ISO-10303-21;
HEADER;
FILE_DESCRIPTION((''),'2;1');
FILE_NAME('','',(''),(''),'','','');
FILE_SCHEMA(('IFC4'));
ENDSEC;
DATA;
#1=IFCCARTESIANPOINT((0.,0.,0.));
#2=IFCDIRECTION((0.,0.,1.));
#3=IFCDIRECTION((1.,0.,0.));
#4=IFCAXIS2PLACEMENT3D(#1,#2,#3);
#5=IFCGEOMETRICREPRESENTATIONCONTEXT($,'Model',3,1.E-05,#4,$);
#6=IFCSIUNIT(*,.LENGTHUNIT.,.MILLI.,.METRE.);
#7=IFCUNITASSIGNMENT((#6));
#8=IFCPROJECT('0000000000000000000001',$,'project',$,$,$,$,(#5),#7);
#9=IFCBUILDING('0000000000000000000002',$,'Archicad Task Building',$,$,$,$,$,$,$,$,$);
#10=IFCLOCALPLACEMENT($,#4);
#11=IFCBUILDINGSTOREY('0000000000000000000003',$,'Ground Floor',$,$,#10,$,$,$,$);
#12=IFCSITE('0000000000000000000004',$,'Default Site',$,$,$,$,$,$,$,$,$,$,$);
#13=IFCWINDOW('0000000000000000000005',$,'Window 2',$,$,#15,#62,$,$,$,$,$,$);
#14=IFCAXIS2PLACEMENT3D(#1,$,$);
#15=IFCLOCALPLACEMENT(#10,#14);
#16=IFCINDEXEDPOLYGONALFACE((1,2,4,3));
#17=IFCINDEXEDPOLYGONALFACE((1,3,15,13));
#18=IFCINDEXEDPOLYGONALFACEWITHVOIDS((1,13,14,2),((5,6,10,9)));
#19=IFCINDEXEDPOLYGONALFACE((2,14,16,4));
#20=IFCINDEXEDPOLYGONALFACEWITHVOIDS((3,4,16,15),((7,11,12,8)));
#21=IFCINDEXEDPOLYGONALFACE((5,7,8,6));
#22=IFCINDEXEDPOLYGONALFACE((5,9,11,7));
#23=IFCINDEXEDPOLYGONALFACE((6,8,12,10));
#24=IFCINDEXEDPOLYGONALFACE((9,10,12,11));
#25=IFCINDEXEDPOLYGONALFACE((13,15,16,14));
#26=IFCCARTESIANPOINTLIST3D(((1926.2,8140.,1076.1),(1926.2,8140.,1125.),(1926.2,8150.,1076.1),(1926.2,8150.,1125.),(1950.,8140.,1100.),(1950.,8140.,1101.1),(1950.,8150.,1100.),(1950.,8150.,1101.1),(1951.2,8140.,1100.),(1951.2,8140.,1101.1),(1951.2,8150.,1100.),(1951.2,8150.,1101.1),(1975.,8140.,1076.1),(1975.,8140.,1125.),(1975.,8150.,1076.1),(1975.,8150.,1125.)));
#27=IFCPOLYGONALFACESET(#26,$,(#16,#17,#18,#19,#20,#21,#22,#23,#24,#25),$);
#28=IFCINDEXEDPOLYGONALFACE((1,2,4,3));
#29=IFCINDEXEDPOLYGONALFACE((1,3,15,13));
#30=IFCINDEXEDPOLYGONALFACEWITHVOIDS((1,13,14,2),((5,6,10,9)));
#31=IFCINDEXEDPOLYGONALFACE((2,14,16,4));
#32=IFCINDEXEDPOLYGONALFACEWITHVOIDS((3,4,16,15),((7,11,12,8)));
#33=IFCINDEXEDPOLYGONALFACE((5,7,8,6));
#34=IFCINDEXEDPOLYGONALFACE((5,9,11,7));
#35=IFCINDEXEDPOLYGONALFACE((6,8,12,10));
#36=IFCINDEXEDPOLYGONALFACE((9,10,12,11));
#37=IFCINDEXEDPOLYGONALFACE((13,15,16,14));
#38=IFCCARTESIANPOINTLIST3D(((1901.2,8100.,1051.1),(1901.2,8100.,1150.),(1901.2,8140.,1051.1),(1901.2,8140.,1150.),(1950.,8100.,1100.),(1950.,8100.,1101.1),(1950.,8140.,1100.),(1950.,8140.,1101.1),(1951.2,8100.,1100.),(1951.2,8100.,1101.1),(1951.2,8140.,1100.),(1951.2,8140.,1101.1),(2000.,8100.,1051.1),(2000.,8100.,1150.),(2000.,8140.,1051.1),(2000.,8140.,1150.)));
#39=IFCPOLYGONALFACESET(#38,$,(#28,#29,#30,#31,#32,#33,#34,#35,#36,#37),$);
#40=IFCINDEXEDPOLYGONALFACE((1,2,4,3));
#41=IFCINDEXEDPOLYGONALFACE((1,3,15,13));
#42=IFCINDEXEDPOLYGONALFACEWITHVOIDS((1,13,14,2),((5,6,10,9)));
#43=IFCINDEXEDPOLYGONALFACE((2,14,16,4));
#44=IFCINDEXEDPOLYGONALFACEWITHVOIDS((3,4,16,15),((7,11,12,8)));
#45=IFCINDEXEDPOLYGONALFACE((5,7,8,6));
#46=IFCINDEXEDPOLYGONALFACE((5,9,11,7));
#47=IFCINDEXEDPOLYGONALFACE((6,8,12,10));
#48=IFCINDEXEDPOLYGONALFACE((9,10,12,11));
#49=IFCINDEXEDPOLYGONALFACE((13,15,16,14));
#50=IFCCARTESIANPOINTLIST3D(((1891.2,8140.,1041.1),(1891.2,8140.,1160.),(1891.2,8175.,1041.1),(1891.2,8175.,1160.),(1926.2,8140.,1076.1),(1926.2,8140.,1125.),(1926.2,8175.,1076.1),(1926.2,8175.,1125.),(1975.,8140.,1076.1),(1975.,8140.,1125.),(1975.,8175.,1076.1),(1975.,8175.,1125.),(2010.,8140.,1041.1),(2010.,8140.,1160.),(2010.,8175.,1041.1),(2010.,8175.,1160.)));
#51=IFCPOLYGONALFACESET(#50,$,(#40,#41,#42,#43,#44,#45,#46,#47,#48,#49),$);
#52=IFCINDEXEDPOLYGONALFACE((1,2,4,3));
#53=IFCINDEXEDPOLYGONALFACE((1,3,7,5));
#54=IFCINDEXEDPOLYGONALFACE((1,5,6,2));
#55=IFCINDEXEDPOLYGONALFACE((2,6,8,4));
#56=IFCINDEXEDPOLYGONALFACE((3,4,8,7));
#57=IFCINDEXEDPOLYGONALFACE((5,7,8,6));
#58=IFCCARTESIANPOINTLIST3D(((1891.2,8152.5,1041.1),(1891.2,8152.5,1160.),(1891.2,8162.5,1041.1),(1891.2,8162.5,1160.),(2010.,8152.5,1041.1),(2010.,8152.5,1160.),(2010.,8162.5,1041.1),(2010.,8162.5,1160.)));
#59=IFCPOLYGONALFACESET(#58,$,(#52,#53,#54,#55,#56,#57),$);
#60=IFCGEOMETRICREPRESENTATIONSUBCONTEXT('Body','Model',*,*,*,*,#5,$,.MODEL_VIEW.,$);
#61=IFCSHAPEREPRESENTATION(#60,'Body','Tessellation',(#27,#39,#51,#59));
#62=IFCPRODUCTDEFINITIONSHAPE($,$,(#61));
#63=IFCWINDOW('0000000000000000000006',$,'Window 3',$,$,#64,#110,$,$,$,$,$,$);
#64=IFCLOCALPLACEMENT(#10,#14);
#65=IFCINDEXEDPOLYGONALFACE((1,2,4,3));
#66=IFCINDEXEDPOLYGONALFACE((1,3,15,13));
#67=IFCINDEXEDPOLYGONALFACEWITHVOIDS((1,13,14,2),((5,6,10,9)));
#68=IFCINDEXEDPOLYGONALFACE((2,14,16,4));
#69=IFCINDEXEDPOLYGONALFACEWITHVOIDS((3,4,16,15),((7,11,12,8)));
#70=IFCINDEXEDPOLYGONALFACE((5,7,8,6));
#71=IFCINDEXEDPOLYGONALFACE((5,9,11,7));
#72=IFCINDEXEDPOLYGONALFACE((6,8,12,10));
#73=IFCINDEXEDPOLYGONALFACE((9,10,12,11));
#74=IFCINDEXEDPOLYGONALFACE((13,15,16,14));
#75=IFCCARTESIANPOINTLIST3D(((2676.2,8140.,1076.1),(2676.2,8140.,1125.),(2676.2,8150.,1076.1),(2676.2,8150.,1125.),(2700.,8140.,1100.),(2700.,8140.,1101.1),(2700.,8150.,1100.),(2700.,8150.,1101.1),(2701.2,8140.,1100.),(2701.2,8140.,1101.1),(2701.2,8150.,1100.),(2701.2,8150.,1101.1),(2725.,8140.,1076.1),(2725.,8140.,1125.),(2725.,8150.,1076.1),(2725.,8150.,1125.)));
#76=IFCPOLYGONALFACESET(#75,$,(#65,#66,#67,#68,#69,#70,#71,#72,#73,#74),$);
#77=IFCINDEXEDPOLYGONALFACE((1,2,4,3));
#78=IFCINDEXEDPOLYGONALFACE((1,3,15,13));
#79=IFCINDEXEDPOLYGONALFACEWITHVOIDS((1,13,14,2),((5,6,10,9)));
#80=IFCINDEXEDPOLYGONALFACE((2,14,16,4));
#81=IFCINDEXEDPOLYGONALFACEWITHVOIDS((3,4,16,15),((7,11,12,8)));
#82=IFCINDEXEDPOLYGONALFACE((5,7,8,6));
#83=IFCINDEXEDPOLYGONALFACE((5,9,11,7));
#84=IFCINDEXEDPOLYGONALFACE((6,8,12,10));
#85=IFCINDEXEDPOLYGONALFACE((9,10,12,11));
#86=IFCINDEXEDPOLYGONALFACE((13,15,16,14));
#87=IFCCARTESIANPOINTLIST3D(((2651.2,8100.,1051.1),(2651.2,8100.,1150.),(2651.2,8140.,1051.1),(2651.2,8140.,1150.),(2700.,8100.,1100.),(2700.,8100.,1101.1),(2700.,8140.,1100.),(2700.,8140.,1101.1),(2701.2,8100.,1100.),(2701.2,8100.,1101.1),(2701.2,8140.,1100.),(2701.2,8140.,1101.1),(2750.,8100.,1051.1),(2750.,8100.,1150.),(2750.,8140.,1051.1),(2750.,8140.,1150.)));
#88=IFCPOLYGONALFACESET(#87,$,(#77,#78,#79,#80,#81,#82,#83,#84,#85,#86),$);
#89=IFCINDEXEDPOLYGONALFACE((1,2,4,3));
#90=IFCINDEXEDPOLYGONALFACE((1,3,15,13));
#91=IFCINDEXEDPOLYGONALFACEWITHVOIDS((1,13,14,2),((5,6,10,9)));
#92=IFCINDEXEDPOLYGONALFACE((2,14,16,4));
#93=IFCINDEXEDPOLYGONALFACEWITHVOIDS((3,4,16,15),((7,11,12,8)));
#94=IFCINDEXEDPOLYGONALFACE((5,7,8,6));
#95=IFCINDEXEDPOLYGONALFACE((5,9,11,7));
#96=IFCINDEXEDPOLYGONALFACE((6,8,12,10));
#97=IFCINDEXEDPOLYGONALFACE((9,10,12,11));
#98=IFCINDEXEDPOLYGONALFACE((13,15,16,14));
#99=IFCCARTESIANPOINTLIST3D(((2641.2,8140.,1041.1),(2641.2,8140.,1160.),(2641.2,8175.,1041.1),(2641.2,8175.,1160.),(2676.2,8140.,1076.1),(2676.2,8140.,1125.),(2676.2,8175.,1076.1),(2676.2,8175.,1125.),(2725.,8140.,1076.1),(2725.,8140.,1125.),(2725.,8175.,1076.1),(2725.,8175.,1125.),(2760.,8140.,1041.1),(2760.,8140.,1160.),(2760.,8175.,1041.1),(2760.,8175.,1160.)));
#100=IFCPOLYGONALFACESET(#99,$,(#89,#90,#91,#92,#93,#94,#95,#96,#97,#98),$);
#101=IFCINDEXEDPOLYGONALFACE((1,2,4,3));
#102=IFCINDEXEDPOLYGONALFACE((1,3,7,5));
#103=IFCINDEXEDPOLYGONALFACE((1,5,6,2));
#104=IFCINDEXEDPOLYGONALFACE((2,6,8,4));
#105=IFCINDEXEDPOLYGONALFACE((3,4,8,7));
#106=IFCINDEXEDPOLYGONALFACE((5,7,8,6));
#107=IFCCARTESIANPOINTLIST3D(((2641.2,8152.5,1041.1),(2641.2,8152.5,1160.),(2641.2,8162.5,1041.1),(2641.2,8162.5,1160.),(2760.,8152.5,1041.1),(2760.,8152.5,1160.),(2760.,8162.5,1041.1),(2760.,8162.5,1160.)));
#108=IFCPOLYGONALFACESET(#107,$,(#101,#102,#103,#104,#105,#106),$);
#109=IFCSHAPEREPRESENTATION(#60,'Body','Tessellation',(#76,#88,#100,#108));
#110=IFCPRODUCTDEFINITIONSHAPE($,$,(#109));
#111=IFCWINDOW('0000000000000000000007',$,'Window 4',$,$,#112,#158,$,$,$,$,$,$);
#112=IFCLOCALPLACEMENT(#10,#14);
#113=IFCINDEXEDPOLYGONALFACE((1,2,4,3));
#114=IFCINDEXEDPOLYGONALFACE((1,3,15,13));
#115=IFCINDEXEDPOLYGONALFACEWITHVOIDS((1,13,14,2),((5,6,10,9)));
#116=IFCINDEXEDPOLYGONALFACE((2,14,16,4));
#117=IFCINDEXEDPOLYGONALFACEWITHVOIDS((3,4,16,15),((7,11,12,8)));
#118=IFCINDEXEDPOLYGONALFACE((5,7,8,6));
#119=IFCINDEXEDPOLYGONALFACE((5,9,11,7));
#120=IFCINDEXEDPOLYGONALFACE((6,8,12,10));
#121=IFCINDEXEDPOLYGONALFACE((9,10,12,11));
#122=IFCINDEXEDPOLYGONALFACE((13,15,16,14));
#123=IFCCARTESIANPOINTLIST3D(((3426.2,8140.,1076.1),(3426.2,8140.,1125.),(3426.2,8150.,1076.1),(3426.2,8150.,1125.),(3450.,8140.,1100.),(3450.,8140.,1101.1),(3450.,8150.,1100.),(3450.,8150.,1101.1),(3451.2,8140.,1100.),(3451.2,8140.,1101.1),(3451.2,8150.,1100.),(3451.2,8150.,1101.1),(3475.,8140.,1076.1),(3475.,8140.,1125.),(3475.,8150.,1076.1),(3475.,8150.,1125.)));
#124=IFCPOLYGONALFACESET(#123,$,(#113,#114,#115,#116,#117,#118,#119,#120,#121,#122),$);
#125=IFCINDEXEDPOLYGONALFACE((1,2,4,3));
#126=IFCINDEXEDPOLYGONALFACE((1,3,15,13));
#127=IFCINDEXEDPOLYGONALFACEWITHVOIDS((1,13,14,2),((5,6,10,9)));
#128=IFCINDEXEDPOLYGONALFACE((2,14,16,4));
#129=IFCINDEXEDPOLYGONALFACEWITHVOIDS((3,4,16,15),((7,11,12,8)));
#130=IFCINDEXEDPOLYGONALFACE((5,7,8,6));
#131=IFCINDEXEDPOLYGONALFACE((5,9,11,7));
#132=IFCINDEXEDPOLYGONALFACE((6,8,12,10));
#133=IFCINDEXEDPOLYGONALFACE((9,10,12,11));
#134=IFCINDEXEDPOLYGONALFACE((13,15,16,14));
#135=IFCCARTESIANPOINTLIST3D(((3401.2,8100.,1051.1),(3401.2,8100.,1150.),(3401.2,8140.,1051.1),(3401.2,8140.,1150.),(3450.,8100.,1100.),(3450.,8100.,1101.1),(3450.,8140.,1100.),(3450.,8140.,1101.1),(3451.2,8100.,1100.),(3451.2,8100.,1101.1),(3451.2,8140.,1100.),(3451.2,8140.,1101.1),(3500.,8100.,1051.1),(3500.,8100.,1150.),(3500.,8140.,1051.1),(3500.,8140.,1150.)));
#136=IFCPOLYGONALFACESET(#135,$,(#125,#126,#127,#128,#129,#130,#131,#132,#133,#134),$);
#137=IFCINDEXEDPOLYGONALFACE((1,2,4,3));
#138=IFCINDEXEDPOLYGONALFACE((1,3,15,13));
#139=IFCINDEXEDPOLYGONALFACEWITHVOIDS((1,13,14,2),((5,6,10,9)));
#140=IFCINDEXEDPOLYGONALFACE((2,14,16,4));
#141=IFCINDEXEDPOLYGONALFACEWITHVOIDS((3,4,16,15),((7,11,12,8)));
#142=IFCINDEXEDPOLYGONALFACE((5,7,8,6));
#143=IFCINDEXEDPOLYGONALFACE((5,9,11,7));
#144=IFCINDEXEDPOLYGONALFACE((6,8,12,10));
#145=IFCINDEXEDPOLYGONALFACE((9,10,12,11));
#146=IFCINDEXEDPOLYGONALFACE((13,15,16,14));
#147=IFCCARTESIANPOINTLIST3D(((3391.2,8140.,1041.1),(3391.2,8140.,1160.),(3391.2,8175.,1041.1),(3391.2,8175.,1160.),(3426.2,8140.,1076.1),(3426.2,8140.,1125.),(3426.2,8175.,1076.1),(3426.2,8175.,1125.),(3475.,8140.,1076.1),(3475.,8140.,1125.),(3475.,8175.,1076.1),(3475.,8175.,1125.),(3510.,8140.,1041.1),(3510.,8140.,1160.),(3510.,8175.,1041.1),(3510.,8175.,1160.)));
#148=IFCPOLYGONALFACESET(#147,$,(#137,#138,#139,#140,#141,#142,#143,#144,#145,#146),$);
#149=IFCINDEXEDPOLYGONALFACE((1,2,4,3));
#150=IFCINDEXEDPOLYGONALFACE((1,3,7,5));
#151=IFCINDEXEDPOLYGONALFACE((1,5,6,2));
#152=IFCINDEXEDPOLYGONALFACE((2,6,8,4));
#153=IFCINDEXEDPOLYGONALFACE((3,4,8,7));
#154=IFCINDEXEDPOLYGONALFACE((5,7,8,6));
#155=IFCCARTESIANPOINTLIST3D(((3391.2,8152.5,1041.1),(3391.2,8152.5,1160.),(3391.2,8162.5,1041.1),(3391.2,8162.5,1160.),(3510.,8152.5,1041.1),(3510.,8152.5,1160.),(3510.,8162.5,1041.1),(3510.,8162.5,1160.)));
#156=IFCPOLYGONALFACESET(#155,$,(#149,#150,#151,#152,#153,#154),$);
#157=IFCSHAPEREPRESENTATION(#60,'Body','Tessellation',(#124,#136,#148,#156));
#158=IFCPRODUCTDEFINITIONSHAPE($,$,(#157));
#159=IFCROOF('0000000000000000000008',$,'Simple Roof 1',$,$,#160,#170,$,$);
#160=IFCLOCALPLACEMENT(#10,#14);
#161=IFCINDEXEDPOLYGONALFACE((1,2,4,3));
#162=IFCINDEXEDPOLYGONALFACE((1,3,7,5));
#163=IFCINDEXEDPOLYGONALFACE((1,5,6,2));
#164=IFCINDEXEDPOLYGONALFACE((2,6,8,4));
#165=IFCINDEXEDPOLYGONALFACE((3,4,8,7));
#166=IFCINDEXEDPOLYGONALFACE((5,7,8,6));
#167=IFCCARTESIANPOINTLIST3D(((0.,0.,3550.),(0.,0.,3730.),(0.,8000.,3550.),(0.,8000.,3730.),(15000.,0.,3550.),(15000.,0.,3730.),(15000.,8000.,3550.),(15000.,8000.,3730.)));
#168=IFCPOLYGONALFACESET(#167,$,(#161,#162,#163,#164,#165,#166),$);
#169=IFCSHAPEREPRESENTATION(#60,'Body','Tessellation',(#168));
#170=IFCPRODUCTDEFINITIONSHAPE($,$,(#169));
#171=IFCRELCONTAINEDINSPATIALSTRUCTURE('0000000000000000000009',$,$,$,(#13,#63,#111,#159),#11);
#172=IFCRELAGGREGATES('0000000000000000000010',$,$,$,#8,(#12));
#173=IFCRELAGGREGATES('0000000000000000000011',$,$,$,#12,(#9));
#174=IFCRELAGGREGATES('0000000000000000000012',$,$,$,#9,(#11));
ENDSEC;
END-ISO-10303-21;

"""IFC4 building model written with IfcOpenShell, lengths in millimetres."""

from ifc_helpers import new_model, si_unit, frame, origin_with_axes, place, context, subcontext, project, spatial, line, indexed_curve, outline, extrude, element, save


model = new_model("IFC4")

# Units and contexts
model_context = context("Model", 3, precision=1e-05, world=origin_with_axes())
body_context = subcontext(model_context, "Body", "Model", "MODEL_VIEW")
ifc_project = project(units=[si_unit("LENGTHUNIT", "METRE", prefix="MILLI")], contexts=[model_context])

# Site, building, storey
site = spatial("IfcSite", under=ifc_project, Name="Default Site")
building = spatial("IfcBuilding", under=site, Name="Archicad Task Building")
storey_placement = place(None, origin_with_axes())
storey = spatial("IfcBuildingStorey", under=building, at=storey_placement, Name="Ground Floor")

# Windows
for number, where, z_axis, x_axis, name in (
    (1, (1950.0, 8050.0, 1100.0), (0.0, 0.0, 1.0), (1.0, 0.0, 0.0), "Window 2"),
    (2, (2700.0, 8050.0, 1100.0), (0.0, 0.0, 1.0), (1.0, 0.0, 0.0), "Window 3"),
    (3, (3450.0, 8050.0, 1100.0), (0.0, 0.0, 1.0), (1.0, 0.0, 0.0), "Window 4"),
):
    element("IfcWindow", number, at=place(storey_placement, frame(where, z_axis=z_axis, x_axis=x_axis)), inside=storey, Name=name, context=body_context, shape_type="SweptSolid", body=[
        extrude(outline(indexed_curve([(0.0, 0.0), (1.2, 0.0), (1.2, 1.1), (0.0, 1.1)], segments=[line(1, 2, 3, 4, 1)]), holes=[indexed_curve([(25.0, 25.0), (-23.8, 25.0), (-23.8, -23.9), (25.0, -23.9)], segments=[line(1, 2, 3, 4, 1)])]), frame((0.0, 90.0, 0.0), z_axis=(0.0, -1.0, 0.0), x_axis=(1.0, 0.0, 0.0)), (0.0, 0.0, -1.0), 10.0),
        extrude(outline(indexed_curve([(0.0, 0.0), (1.2, 0.0), (1.2, 1.1), (0.0, 1.1)], segments=[line(1, 2, 3, 4, 1)]), holes=[indexed_curve([(50.0, 50.0), (-48.8, 50.0), (-48.8, -48.9), (50.0, -48.9)], segments=[line(1, 2, 3, 4, 1)])]), frame((0.0, 50.0, 0.0), z_axis=(0.0, -1.0, 0.0), x_axis=(1.0, 0.0, 0.0)), (0.0, 0.0, -1.0), 40.0),
        extrude(outline(indexed_curve([(0.0, 0.0), (-48.8, 0.0), (-48.8, -48.9), (0.0, -48.9)], segments=[line(1, 2, 3, 4, 1)]), holes=[indexed_curve([(35.0, 35.0), (-83.8, 35.0), (-83.8, -83.9), (35.0, -83.9)], segments=[line(1, 2, 3, 4, 1)])]), frame((25.0, 90.0, 25.0), z_axis=(0.0, -1.0, 0.0), x_axis=(1.0, 0.0, 0.0)), (0.0, 0.0, -1.0), 35.0),
        extrude(outline(indexed_curve([(35.0, 35.0), (-83.8, 35.0), (-83.8, -83.9), (35.0, -83.9)], segments=[line(1, 2, 3, 4, 1)])), frame((25.0, 102.5, 25.0), z_axis=(0.0, -1.0, 0.0), x_axis=(1.0, 0.0, 0.0)), (0.0, 0.0, -1.0), 10.0),
    ])

# Roof
roof_placement = place(storey_placement, frame((0.0, 0.0, 3550.0), z_axis=(0.0, 0.0, 1.0), x_axis=(1.0, 0.0, 0.0)))
element("IfcRoof", 4, at=roof_placement, inside=storey, Name="Simple Roof 1", context=body_context, shape_type="SweptSolid", body=[
    extrude(outline(indexed_curve([(0.0, 0.0), (15000.0, 0.0), (15000.0, 8000.0), (0.0, 8000.0), (0.0, 0.0)])), None, (0.0, 0.0, 1.0), 180.0),
])

save(model, "model.ifc")
